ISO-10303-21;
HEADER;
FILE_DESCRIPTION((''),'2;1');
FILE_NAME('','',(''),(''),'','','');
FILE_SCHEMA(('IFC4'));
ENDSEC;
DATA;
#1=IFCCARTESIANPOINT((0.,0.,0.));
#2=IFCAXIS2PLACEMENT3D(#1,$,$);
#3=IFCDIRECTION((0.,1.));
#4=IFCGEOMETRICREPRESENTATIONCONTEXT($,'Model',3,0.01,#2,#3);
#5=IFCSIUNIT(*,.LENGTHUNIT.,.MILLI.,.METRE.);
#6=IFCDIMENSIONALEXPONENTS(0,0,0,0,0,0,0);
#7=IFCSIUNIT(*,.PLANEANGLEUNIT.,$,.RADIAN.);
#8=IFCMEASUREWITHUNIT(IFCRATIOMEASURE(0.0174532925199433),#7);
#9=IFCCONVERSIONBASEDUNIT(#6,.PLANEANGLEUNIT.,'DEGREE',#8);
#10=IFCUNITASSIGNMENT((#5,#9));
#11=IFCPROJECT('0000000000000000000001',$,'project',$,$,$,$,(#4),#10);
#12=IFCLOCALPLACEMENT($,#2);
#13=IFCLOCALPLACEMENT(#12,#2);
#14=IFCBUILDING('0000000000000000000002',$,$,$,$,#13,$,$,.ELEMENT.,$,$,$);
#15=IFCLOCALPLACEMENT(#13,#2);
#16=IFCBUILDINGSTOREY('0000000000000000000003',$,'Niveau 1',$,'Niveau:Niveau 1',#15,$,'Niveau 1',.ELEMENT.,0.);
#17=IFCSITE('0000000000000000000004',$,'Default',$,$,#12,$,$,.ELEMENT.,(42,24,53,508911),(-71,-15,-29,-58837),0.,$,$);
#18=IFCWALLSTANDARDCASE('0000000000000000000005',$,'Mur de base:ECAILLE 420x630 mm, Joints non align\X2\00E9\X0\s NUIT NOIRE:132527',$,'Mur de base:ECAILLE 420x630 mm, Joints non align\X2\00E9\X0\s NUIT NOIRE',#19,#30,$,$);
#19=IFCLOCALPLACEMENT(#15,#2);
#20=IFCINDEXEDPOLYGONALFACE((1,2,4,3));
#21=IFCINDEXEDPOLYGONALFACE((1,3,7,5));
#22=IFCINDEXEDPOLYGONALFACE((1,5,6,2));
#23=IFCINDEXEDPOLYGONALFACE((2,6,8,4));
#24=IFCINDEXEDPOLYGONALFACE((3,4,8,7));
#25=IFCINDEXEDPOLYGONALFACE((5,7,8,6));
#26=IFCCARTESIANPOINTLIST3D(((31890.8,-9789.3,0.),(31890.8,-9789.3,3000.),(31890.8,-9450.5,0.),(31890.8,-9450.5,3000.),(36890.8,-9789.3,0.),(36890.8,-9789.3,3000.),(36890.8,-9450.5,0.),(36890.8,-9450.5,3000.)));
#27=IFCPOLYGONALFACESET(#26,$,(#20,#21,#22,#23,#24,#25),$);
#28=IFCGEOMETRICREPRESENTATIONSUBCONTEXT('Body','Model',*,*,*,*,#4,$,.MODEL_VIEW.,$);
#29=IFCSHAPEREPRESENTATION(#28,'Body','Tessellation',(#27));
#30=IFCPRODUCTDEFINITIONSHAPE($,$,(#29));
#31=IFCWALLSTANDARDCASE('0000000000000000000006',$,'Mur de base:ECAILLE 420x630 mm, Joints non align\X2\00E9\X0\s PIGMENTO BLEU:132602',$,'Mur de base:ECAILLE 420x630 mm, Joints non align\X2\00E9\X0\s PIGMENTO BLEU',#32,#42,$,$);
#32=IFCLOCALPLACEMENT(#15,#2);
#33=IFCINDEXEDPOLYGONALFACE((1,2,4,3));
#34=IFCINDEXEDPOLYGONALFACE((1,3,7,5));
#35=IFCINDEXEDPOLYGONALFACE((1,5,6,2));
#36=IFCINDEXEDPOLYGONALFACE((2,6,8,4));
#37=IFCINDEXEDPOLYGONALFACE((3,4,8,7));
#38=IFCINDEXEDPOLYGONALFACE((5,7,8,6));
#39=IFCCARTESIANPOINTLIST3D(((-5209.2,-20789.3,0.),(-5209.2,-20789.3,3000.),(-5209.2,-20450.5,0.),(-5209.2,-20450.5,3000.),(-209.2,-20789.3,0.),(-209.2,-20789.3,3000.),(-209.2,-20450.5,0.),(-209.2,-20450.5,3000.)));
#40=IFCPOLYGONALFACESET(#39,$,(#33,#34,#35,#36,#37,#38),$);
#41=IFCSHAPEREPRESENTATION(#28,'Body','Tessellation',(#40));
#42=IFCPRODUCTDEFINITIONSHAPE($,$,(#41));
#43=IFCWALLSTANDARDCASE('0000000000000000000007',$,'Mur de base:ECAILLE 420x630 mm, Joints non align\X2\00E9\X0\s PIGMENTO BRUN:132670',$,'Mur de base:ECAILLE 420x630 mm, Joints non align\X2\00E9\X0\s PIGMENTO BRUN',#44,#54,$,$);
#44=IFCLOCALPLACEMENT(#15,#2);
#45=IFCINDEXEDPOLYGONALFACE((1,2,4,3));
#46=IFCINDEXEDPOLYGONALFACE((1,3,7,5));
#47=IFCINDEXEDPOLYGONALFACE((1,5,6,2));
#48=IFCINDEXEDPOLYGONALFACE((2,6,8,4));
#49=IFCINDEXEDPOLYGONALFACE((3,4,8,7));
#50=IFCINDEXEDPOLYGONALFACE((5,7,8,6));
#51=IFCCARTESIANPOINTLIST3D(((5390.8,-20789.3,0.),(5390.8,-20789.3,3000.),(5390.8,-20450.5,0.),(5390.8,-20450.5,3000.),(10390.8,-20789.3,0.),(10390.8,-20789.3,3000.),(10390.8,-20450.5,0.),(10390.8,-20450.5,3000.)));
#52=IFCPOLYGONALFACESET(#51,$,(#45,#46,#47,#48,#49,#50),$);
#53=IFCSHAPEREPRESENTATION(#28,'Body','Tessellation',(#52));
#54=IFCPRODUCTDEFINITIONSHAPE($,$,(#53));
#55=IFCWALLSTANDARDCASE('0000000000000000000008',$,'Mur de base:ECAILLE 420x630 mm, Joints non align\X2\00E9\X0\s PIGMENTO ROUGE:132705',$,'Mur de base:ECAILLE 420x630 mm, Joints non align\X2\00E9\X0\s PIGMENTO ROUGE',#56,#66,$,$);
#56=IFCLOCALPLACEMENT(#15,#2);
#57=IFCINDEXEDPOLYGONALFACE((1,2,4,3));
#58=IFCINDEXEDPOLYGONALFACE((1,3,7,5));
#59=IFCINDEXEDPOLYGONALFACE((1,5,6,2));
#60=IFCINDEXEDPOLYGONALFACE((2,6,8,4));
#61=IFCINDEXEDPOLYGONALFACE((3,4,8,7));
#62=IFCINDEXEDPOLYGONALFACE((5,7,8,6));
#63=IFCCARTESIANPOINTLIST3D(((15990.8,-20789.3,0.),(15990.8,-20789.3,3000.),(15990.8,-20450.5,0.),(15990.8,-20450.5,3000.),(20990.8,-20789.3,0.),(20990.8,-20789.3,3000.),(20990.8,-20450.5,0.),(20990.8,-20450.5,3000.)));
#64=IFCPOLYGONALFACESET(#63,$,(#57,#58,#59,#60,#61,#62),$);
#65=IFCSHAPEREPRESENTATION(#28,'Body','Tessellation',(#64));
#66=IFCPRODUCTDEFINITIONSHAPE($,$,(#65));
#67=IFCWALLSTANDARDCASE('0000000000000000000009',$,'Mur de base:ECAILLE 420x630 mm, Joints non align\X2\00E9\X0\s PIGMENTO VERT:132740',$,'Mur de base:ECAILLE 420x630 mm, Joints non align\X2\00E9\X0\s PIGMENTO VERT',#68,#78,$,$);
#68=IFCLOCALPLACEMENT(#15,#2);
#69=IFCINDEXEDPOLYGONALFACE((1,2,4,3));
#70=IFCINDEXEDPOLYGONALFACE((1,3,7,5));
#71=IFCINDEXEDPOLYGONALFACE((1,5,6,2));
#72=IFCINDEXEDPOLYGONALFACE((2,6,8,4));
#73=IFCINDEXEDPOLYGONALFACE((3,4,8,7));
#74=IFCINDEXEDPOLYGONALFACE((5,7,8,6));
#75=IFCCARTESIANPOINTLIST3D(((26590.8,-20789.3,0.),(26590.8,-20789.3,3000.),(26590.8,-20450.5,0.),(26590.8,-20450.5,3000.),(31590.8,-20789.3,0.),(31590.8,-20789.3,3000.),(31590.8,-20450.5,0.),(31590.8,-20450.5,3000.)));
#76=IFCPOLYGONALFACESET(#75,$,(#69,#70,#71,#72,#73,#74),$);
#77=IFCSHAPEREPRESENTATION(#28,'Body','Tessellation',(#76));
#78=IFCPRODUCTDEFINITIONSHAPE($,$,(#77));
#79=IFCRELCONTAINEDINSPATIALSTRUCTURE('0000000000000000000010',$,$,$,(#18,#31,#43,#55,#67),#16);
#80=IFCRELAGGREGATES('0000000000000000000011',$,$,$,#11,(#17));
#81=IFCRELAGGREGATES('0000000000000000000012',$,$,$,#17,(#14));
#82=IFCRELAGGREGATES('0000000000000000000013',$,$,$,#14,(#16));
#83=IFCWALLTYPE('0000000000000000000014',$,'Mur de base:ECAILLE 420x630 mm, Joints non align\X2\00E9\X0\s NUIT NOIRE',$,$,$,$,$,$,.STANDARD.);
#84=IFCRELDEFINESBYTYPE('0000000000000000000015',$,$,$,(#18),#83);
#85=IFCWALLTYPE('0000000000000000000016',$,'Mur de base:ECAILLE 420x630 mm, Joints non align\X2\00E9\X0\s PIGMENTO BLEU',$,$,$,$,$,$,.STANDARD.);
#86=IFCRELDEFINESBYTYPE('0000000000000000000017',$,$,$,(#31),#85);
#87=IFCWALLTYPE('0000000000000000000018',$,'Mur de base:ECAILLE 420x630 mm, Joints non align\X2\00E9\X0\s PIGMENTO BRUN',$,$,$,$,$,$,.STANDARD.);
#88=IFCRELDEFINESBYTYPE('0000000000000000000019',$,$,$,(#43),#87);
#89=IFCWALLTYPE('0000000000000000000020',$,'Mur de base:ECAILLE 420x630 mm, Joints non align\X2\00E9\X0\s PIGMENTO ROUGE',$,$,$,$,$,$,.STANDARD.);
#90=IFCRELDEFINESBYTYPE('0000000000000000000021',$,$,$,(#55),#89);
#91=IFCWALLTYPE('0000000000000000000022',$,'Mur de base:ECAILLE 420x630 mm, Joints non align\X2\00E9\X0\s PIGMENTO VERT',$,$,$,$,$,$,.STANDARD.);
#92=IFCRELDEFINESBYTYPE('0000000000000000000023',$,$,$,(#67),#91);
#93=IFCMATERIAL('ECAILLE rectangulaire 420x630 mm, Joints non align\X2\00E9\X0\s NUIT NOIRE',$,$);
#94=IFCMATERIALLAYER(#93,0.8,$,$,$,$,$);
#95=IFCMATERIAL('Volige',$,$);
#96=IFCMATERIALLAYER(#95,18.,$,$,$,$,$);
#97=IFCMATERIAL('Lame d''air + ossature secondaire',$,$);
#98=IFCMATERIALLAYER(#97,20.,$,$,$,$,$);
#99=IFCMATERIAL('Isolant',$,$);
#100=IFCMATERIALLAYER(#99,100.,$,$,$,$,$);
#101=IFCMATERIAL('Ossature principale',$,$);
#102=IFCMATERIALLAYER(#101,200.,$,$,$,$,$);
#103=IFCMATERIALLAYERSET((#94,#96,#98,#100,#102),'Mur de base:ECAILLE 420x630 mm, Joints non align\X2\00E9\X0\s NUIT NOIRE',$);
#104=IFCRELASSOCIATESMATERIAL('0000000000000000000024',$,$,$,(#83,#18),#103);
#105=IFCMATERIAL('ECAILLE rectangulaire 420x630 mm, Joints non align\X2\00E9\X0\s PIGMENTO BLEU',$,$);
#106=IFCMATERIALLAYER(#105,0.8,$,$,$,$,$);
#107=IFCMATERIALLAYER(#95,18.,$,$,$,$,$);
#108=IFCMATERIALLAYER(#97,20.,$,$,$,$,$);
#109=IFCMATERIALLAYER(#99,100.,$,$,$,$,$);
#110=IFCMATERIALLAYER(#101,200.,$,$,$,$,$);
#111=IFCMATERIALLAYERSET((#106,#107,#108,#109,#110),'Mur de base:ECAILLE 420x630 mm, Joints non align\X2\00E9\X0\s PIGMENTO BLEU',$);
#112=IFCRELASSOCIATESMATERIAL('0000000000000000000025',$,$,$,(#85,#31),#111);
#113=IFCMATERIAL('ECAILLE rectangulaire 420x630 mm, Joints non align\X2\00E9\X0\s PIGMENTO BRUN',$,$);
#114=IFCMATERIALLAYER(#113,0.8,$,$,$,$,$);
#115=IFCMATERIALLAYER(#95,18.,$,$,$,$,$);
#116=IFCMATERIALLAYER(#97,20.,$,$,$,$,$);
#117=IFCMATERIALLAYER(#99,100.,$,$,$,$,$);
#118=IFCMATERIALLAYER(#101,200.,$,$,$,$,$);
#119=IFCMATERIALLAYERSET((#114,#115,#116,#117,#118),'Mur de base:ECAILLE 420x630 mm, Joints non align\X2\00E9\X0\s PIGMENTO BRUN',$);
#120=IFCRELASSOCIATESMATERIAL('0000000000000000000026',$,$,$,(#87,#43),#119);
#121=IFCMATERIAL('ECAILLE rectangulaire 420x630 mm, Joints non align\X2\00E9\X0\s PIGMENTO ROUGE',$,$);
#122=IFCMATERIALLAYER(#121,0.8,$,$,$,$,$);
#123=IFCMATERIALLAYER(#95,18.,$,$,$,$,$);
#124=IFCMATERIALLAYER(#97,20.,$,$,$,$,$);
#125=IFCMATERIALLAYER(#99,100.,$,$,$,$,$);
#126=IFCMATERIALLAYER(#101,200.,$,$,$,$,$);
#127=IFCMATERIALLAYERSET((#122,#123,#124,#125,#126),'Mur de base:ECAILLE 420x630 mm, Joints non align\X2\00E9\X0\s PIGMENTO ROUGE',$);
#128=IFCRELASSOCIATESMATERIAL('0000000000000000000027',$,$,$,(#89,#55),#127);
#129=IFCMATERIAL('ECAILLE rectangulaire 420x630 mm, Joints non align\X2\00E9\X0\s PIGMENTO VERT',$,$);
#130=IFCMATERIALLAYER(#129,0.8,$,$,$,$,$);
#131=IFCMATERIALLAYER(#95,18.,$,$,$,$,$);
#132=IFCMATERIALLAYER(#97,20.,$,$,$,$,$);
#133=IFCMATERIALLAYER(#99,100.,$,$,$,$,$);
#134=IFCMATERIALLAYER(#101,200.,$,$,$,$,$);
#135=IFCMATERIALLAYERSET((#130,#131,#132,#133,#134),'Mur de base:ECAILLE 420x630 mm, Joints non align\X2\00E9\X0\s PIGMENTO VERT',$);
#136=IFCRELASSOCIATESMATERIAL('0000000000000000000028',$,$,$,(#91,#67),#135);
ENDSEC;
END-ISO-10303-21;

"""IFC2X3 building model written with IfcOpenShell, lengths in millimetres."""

from ifc_helpers import new_model, entity, si_unit, converted_unit, direction, frame, frame_2d, origin, place, context, subcontext, project, spatial, rectangle, extrude, material, layer, layer_set, layer_usage, type_object, element, save


model = new_model("IFC2X3")

# Units and contexts
model_context = context("Model", 3, precision=0.01, world=origin(), true_north=direction((0.0, 1.0)))
body_context = subcontext(model_context, "Body", "Model", "MODEL_VIEW")
ifc_project = project(units=[si_unit("LENGTHUNIT", "METRE", prefix="MILLI"), converted_unit("PLANEANGLEUNIT", "DEGREE", entity("IfcRatioMeasure", 0.0174532925199433), si_unit("PLANEANGLEUNIT", "RADIAN"), dimensions=[0, 0, 0, 0, 0, 0, 0])], contexts=[model_context])

# Site, building, storey
site_placement = place(None, origin())
site = spatial("IfcSite", under=ifc_project, at=site_placement, Name="Default", CompositionType="ELEMENT", RefLatitude=(42, 24, 53, 508911), RefLongitude=(-71, -15, -29, -58837), RefElevation=0.0)
building_placement = place(site_placement, origin())
building = spatial("IfcBuilding", under=site, at=building_placement, CompositionType="ELEMENT")
storey_placement = place(building_placement, origin())
storey = spatial("IfcBuildingStorey", under=building, at=storey_placement, Name="Niveau 1", ObjectType="Niveau:Niveau 1", LongName="Niveau 1", CompositionType="ELEMENT", Elevation=0.0)

# Walls
ifc_material_1 = material(Name="Volige")
ifc_material_2 = material(Name="Lame d'air + ossature secondaire")
ifc_material_3 = material(Name="Isolant")
ifc_material_4 = material(Name="Ossature principale")
ifc_material_5 = material(Name="ECAILLE rectangulaire 420x630 mm, Joints non alignés NUIT NOIRE")
ifc_layer_1 = layer(ifc_material_5, 0.8)
ifc_layer_2 = layer(ifc_material_1, 18.0)
ifc_layer_3 = layer(ifc_material_2, 20.0)
ifc_layer_4 = layer(ifc_material_3, 100.0)
ifc_layer_5 = layer(ifc_material_4, 200.0)
ifc_layer_set_1 = layer_set([ifc_layer_1, ifc_layer_2, ifc_layer_3, ifc_layer_4, ifc_layer_5], Name="Mur de base:ECAILLE 420x630 mm, Joints non alignés NUIT NOIRE")
ifc_layer_usage_1 = layer_usage(ifc_layer_set_1, "AXIS2", "NEGATIVE", 169.4)
wall_type_1 = type_object("IfcWallType", Name="Mur de base:ECAILLE 420x630 mm, Joints non alignés NUIT NOIRE", PredefinedType="STANDARD", material=ifc_layer_set_1)
wall_1_placement = place(storey_placement, frame((36890.8, -9619.9, 0.0), z_axis=(0.0, 0.0, 1.0), x_axis=(-1.0, 0.0, 0.0)))
element("IfcWallStandardCase", 1, at=wall_1_placement, inside=storey, type_object=wall_type_1, material=ifc_layer_usage_1, Name="Mur de base:ECAILLE 420x630 mm, Joints non alignés NUIT NOIRE:132527", ObjectType="Mur de base:ECAILLE 420x630 mm, Joints non alignés NUIT NOIRE", context=body_context, shape_type="SweptSolid", body=[
    extrude(rectangle(XDim=5000.0, YDim=338.8, at=frame_2d((2500.0, 0.0), x_axis=(-1.0, 0.0))), origin(), (0.0, 0.0, 1.0), 3000.0),
])
ifc_material_6 = material(Name="ECAILLE rectangulaire 420x630 mm, Joints non alignés PIGMENTO BLEU")
ifc_layer_6 = layer(ifc_material_6, 0.8)
ifc_layer_7 = layer(ifc_material_1, 18.0)
ifc_layer_8 = layer(ifc_material_2, 20.0)
ifc_layer_9 = layer(ifc_material_3, 100.0)
ifc_layer_10 = layer(ifc_material_4, 200.0)
ifc_layer_set_2 = layer_set([ifc_layer_6, ifc_layer_7, ifc_layer_8, ifc_layer_9, ifc_layer_10], Name="Mur de base:ECAILLE 420x630 mm, Joints non alignés PIGMENTO BLEU")
ifc_layer_usage_2 = layer_usage(ifc_layer_set_2, "AXIS2", "NEGATIVE", 169.4)
wall_type_2 = type_object("IfcWallType", Name="Mur de base:ECAILLE 420x630 mm, Joints non alignés PIGMENTO BLEU", PredefinedType="STANDARD", material=ifc_layer_set_2)
wall_2_placement = place(storey_placement, frame((-209.2, -20619.9, 0.0), z_axis=(0.0, 0.0, 1.0), x_axis=(-1.0, 0.0, 0.0)))
element("IfcWallStandardCase", 2, at=wall_2_placement, inside=storey, type_object=wall_type_2, material=ifc_layer_usage_2, Name="Mur de base:ECAILLE 420x630 mm, Joints non alignés PIGMENTO BLEU:132602", ObjectType="Mur de base:ECAILLE 420x630 mm, Joints non alignés PIGMENTO BLEU", context=body_context, shape_type="SweptSolid", body=[
    extrude(rectangle(XDim=5000.0, YDim=338.8, at=frame_2d((2500.0, 0.0), x_axis=(-1.0, 0.0))), origin(), (0.0, 0.0, 1.0), 3000.0),
])
ifc_material_7 = material(Name="ECAILLE rectangulaire 420x630 mm, Joints non alignés PIGMENTO BRUN")
ifc_layer_11 = layer(ifc_material_7, 0.8)
ifc_layer_12 = layer(ifc_material_1, 18.0)
ifc_layer_13 = layer(ifc_material_2, 20.0)
ifc_layer_14 = layer(ifc_material_3, 100.0)
ifc_layer_15 = layer(ifc_material_4, 200.0)
ifc_layer_set_3 = layer_set([ifc_layer_11, ifc_layer_12, ifc_layer_13, ifc_layer_14, ifc_layer_15], Name="Mur de base:ECAILLE 420x630 mm, Joints non alignés PIGMENTO BRUN")
ifc_layer_usage_3 = layer_usage(ifc_layer_set_3, "AXIS2", "NEGATIVE", 169.4)
wall_type_3 = type_object("IfcWallType", Name="Mur de base:ECAILLE 420x630 mm, Joints non alignés PIGMENTO BRUN", PredefinedType="STANDARD", material=ifc_layer_set_3)
wall_3_placement = place(storey_placement, frame((10390.8, -20619.9, 0.0), z_axis=(0.0, 0.0, 1.0), x_axis=(-1.0, 0.0, 0.0)))
element("IfcWallStandardCase", 3, at=wall_3_placement, inside=storey, type_object=wall_type_3, material=ifc_layer_usage_3, Name="Mur de base:ECAILLE 420x630 mm, Joints non alignés PIGMENTO BRUN:132670", ObjectType="Mur de base:ECAILLE 420x630 mm, Joints non alignés PIGMENTO BRUN", context=body_context, shape_type="SweptSolid", body=[
    extrude(rectangle(XDim=5000.0, YDim=338.8, at=frame_2d((2500.0, 0.0), x_axis=(-1.0, 0.0))), origin(), (0.0, 0.0, 1.0), 3000.0),
])
ifc_material_8 = material(Name="ECAILLE rectangulaire 420x630 mm, Joints non alignés PIGMENTO ROUGE")
ifc_layer_16 = layer(ifc_material_8, 0.8)
ifc_layer_17 = layer(ifc_material_1, 18.0)
ifc_layer_18 = layer(ifc_material_2, 20.0)
ifc_layer_19 = layer(ifc_material_3, 100.0)
ifc_layer_20 = layer(ifc_material_4, 200.0)
ifc_layer_set_4 = layer_set([ifc_layer_16, ifc_layer_17, ifc_layer_18, ifc_layer_19, ifc_layer_20], Name="Mur de base:ECAILLE 420x630 mm, Joints non alignés PIGMENTO ROUGE")
ifc_layer_usage_4 = layer_usage(ifc_layer_set_4, "AXIS2", "NEGATIVE", 169.4)
wall_type_4 = type_object("IfcWallType", Name="Mur de base:ECAILLE 420x630 mm, Joints non alignés PIGMENTO ROUGE", PredefinedType="STANDARD", material=ifc_layer_set_4)
wall_4_placement = place(storey_placement, frame((20990.8, -20619.9, 0.0), z_axis=(0.0, 0.0, 1.0), x_axis=(-1.0, 0.0, 0.0)))
element("IfcWallStandardCase", 4, at=wall_4_placement, inside=storey, type_object=wall_type_4, material=ifc_layer_usage_4, Name="Mur de base:ECAILLE 420x630 mm, Joints non alignés PIGMENTO ROUGE:132705", ObjectType="Mur de base:ECAILLE 420x630 mm, Joints non alignés PIGMENTO ROUGE", context=body_context, shape_type="SweptSolid", body=[
    extrude(rectangle(XDim=5000.0, YDim=338.8, at=frame_2d((2500.0, 0.0), x_axis=(-1.0, 0.0))), origin(), (0.0, 0.0, 1.0), 3000.0),
])
ifc_material_9 = material(Name="ECAILLE rectangulaire 420x630 mm, Joints non alignés PIGMENTO VERT")
ifc_layer_21 = layer(ifc_material_9, 0.8)
ifc_layer_22 = layer(ifc_material_1, 18.0)
ifc_layer_23 = layer(ifc_material_2, 20.0)
ifc_layer_24 = layer(ifc_material_3, 100.0)
ifc_layer_25 = layer(ifc_material_4, 200.0)
ifc_layer_set_5 = layer_set([ifc_layer_21, ifc_layer_22, ifc_layer_23, ifc_layer_24, ifc_layer_25], Name="Mur de base:ECAILLE 420x630 mm, Joints non alignés PIGMENTO VERT")
ifc_layer_usage_5 = layer_usage(ifc_layer_set_5, "AXIS2", "NEGATIVE", 169.4)
wall_type_5 = type_object("IfcWallType", Name="Mur de base:ECAILLE 420x630 mm, Joints non alignés PIGMENTO VERT", PredefinedType="STANDARD", material=ifc_layer_set_5)
wall_5_placement = place(storey_placement, frame((31590.8, -20619.9, 0.0), z_axis=(0.0, 0.0, 1.0), x_axis=(-1.0, 0.0, 0.0)))
element("IfcWallStandardCase", 5, at=wall_5_placement, inside=storey, type_object=wall_type_5, material=ifc_layer_usage_5, Name="Mur de base:ECAILLE 420x630 mm, Joints non alignés PIGMENTO VERT:132740", ObjectType="Mur de base:ECAILLE 420x630 mm, Joints non alignés PIGMENTO VERT", context=body_context, shape_type="SweptSolid", body=[
    extrude(rectangle(XDim=5000.0, YDim=338.8, at=frame_2d((2500.0, 0.0), x_axis=(-1.0, 0.0))), origin(), (0.0, 0.0, 1.0), 3000.0),
])

save(model, "model.ifc")
